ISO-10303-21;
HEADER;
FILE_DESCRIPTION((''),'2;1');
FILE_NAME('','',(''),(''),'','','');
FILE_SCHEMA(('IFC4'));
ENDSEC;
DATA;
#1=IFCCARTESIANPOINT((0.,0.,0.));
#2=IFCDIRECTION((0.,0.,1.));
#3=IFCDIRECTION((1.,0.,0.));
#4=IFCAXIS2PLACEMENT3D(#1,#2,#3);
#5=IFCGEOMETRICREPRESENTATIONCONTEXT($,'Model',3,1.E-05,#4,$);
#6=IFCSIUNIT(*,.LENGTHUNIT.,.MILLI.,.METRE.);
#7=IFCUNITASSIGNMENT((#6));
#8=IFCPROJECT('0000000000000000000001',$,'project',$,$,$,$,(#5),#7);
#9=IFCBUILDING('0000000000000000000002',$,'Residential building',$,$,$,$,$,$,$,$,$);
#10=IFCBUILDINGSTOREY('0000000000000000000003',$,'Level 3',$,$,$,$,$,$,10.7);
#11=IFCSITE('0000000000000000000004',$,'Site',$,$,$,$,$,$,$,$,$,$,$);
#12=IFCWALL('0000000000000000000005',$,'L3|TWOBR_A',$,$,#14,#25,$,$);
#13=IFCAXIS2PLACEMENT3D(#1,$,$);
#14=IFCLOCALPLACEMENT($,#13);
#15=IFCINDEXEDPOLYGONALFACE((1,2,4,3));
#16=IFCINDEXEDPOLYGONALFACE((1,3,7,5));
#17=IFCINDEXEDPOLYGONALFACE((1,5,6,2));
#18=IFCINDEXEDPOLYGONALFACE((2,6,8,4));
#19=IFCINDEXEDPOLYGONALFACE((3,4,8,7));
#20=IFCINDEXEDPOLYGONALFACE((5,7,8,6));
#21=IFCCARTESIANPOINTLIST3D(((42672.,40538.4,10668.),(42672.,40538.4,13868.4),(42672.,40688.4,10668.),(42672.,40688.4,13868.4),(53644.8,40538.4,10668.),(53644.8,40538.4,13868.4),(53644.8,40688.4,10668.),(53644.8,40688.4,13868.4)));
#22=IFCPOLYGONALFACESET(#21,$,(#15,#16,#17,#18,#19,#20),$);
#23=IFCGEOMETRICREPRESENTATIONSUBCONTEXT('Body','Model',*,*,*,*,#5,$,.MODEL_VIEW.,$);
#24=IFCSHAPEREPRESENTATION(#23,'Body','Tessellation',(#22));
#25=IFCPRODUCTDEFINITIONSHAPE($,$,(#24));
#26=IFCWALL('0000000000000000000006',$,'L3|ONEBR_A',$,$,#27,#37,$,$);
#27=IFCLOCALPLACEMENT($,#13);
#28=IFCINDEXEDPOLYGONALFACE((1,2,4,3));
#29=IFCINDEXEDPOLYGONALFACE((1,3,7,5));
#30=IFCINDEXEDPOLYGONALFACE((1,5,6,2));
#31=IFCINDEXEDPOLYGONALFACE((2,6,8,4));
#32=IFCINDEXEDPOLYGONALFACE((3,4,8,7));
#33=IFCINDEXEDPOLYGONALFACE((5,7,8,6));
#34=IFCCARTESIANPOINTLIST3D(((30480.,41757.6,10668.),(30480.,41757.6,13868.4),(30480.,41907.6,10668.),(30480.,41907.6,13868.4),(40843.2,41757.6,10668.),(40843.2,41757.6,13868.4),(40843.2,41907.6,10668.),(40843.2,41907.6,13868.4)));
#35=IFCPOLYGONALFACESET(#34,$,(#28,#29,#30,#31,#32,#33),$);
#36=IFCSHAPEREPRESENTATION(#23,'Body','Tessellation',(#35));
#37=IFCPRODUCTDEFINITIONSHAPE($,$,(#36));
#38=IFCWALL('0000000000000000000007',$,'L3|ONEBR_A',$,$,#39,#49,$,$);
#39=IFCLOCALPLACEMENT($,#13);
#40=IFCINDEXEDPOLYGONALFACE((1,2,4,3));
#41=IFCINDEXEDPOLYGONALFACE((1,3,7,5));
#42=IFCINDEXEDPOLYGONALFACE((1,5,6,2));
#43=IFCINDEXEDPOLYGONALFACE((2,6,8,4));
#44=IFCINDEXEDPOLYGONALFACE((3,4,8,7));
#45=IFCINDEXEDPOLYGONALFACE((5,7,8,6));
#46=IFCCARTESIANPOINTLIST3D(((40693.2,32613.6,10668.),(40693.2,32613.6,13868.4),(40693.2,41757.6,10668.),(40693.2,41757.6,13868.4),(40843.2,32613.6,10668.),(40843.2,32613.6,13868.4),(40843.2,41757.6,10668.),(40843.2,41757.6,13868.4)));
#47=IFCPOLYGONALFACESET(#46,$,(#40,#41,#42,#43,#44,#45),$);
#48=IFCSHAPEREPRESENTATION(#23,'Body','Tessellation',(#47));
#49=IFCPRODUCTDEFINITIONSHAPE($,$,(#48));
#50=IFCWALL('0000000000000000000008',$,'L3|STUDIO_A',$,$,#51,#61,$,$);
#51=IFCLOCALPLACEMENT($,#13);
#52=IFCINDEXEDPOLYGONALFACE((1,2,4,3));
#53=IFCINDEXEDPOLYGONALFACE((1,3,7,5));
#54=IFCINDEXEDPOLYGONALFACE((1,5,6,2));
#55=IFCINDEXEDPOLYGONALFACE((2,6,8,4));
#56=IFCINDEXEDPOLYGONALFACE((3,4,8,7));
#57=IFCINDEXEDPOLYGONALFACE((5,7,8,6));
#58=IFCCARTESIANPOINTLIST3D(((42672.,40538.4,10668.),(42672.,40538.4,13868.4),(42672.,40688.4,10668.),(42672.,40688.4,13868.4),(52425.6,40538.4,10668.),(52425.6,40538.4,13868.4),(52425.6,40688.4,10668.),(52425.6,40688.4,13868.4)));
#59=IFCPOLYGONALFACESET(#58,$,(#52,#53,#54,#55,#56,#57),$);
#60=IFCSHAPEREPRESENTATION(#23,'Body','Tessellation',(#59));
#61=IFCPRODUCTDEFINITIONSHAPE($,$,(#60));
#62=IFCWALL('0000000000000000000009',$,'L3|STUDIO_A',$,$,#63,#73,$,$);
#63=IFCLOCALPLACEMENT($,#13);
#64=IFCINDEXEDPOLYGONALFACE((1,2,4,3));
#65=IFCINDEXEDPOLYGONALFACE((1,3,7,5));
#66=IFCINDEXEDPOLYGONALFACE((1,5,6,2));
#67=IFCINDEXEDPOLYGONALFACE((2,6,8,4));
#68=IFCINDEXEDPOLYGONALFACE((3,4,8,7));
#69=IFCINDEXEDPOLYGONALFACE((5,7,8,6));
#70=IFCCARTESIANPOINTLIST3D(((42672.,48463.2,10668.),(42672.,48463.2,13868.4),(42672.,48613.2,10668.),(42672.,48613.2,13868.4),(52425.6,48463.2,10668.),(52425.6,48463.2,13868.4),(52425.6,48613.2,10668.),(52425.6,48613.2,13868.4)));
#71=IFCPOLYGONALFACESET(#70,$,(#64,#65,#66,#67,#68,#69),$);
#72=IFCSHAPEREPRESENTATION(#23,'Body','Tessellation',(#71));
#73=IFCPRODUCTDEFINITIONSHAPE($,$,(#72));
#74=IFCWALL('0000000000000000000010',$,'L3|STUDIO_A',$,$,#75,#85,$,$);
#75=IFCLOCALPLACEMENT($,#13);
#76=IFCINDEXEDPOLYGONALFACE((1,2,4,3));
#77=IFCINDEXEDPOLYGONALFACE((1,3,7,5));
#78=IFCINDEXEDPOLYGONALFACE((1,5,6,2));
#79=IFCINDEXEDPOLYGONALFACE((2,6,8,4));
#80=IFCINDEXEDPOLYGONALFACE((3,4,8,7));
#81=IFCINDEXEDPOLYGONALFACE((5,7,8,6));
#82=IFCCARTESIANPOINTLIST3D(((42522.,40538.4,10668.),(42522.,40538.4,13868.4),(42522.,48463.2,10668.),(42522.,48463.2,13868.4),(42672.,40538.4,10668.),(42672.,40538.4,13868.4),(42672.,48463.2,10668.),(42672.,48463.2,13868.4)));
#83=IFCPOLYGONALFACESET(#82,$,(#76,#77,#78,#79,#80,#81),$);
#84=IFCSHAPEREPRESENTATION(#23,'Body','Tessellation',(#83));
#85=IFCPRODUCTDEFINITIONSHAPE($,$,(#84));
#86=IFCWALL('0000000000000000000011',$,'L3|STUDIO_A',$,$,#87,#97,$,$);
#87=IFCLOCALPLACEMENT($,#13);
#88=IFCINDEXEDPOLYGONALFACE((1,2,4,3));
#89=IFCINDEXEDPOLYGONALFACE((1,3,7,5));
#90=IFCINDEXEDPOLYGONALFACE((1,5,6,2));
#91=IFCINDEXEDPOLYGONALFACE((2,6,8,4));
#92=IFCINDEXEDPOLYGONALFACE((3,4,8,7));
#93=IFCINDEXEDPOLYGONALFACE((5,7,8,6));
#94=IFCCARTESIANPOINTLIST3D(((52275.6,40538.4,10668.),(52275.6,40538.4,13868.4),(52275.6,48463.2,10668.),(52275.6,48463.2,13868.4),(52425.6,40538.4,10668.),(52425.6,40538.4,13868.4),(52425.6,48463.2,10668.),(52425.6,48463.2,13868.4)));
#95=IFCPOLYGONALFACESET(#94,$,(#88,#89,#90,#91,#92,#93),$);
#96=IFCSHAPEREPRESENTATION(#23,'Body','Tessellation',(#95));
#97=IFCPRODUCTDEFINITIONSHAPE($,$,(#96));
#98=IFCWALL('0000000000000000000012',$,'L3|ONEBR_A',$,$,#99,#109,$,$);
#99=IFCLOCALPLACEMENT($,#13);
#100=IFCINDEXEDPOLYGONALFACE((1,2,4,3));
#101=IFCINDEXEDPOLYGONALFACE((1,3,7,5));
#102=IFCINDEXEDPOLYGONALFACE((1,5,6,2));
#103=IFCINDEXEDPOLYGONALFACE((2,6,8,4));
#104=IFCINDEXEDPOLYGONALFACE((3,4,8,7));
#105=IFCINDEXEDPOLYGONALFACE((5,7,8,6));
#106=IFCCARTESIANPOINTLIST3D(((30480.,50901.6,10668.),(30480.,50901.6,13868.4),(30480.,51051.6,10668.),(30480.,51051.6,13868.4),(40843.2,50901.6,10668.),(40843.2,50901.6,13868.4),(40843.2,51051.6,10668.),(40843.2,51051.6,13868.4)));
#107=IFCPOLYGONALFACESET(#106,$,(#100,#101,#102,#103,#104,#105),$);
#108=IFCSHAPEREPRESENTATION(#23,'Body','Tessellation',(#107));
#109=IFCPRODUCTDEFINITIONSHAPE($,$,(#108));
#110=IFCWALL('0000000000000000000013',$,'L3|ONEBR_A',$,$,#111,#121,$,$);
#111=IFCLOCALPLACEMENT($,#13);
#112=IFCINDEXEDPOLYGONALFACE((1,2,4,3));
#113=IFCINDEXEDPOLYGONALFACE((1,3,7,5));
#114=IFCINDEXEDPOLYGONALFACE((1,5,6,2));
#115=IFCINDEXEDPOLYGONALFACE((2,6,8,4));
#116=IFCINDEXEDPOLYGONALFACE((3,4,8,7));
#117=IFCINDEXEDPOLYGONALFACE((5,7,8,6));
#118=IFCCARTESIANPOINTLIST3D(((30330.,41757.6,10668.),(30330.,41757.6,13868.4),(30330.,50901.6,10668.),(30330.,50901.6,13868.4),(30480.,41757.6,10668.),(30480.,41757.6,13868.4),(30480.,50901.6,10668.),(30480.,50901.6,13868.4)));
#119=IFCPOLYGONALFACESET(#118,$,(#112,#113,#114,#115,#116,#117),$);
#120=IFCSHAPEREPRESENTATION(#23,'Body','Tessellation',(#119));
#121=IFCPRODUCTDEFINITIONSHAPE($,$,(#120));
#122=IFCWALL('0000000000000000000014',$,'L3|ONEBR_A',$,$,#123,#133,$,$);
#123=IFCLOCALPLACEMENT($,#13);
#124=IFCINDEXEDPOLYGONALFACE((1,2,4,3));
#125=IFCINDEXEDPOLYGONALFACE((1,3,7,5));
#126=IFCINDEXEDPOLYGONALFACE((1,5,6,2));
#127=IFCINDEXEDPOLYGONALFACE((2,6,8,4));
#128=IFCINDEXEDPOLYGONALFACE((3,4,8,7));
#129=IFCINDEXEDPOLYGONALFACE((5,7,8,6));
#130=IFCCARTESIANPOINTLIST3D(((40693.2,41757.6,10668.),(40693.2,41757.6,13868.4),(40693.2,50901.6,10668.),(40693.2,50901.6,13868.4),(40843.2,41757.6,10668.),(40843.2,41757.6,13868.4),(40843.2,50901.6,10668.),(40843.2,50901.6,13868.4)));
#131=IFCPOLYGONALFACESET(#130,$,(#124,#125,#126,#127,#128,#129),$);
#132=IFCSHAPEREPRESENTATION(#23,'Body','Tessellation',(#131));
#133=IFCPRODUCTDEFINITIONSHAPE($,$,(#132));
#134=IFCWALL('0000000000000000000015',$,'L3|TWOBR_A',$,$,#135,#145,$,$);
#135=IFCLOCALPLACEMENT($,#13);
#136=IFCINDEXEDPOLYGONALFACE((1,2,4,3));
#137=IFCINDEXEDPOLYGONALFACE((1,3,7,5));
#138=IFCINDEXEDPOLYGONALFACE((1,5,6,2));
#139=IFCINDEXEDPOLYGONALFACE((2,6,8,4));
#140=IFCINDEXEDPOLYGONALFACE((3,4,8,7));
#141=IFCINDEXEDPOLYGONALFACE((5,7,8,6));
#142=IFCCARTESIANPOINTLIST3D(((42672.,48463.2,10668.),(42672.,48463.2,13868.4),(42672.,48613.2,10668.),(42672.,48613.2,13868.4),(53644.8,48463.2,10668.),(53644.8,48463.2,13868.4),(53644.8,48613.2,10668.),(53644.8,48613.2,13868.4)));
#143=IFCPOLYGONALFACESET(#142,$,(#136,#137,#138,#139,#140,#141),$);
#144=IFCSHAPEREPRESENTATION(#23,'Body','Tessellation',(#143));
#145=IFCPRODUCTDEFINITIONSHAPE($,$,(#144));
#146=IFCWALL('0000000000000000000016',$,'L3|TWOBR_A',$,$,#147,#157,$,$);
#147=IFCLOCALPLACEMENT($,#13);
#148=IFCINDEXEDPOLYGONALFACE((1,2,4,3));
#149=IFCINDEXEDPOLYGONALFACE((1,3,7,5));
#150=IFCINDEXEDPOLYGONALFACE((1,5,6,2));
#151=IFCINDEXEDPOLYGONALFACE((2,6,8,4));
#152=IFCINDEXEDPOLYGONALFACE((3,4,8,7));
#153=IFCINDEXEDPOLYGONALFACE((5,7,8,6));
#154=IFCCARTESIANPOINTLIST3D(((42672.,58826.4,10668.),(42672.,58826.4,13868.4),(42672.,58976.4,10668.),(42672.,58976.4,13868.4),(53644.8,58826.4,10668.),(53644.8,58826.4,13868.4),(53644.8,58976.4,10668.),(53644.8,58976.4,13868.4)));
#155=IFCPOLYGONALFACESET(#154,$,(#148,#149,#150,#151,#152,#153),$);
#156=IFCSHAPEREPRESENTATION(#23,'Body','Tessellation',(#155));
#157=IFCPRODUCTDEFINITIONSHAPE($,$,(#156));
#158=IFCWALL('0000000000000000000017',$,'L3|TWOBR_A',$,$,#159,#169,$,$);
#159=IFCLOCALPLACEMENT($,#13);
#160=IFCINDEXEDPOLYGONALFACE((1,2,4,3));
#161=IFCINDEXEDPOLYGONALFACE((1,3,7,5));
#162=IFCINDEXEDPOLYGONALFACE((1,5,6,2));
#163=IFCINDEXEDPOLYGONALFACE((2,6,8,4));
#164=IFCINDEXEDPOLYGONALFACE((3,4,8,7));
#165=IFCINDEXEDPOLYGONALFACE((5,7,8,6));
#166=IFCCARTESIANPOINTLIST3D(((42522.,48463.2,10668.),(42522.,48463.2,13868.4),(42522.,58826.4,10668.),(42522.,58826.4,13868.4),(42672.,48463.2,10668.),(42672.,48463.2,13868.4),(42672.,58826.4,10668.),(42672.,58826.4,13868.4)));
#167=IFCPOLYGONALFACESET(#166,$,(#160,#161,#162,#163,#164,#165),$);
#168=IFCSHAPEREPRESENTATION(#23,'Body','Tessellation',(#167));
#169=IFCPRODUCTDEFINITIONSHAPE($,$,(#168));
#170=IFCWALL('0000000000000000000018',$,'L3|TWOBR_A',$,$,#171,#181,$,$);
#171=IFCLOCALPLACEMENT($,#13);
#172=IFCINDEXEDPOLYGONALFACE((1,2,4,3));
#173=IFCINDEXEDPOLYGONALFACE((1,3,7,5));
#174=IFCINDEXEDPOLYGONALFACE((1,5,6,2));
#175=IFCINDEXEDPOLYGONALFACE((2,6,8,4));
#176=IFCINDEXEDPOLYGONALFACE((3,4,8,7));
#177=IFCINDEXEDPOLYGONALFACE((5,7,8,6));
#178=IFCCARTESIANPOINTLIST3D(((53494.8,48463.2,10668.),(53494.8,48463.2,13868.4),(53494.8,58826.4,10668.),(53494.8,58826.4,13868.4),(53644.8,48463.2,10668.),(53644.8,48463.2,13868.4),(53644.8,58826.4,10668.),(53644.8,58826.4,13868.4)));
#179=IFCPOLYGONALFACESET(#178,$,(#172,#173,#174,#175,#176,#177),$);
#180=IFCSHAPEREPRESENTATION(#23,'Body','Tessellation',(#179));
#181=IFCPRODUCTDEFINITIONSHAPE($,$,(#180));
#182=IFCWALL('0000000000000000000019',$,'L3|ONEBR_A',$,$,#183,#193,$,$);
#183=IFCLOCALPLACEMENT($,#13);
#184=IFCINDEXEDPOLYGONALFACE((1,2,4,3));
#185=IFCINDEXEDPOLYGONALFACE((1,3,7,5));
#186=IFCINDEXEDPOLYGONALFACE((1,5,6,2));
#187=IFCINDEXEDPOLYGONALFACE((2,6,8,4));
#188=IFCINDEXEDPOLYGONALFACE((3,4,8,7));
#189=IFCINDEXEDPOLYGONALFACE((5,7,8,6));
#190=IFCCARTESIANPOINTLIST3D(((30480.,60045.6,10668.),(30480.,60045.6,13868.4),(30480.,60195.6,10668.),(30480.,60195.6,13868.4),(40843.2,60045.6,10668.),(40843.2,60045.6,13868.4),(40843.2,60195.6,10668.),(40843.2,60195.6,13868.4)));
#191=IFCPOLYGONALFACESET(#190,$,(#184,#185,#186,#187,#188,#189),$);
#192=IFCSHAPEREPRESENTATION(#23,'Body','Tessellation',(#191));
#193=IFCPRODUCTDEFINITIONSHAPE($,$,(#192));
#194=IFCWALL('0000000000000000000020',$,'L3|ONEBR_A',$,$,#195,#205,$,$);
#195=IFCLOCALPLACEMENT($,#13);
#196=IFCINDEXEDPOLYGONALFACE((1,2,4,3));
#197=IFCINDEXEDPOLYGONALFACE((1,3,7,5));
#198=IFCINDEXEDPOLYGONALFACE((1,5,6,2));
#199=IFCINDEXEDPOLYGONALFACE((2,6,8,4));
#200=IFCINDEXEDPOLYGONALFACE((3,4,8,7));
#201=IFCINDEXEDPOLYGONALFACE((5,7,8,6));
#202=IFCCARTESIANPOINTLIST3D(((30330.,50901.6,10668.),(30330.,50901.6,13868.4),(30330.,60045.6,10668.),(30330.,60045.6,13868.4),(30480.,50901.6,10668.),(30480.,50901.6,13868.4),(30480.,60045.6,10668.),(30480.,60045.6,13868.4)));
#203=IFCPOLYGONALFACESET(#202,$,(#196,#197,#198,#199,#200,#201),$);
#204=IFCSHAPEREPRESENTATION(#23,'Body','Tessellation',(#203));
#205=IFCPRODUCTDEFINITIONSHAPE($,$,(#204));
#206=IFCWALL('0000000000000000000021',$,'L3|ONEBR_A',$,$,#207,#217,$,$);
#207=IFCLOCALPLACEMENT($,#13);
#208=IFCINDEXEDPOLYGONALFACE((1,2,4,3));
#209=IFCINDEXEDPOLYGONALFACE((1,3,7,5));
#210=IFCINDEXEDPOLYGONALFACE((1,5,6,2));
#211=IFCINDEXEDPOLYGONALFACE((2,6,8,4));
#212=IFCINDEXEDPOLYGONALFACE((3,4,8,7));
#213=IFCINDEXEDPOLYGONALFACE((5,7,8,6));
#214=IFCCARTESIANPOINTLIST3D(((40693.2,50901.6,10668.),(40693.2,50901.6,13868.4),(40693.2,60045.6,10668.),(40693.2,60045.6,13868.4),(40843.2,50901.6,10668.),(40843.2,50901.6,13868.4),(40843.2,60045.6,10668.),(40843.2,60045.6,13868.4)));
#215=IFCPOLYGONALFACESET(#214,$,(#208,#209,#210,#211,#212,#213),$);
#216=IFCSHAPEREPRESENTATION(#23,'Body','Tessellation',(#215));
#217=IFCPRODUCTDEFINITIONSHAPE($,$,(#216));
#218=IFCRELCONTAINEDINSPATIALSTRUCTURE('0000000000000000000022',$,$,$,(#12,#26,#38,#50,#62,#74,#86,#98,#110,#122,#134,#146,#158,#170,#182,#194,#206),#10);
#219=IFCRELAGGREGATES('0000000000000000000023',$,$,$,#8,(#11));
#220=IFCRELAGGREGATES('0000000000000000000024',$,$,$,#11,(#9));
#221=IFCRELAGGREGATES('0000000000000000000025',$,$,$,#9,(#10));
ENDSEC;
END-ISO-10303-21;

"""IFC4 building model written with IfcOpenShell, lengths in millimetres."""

from ifc_helpers import new_model, si_unit, frame, origin_with_axes, place, context, subcontext, project, spatial, indexed_curve, outline, extrude, element, save


model = new_model("IFC4")

# Units and contexts
model_context = context("Model", 3, precision=1e-05, world=origin_with_axes())
body_context = subcontext(model_context, "Body", "Model", "MODEL_VIEW")
ifc_project = project(units=[si_unit("LENGTHUNIT", "METRE", prefix="MILLI")], contexts=[model_context])

# Site, building, storey
site = spatial("IfcSite", under=ifc_project, Name="Site")
building = spatial("IfcBuilding", under=site, Name="Residential building")
storey = spatial("IfcBuildingStorey", under=building, Name="Level 3", Elevation=10.7)

# Walls
wall_1_placement = place(None, frame((42672.0, 40538.4, 10668.0), z_axis=(0.0, 0.0, 1.0), x_axis=(1.0, 0.0, 0.0)))
element("IfcWall", 1, at=wall_1_placement, inside=storey, Name="L3|TWOBR_A", context=body_context, shape_type="SweptSolid", body=[
    extrude(outline(indexed_curve([(0.0, 0.0), (0.0, 150.0), (10972.8, 150.0), (10972.8, 0.0), (0.0, 0.0)], self_intersect=False)), origin_with_axes(), (0.0, 0.0, 1.0), 3200.4),
])
wall_2_placement = place(None, frame((30480.0, 41757.6, 10668.0), z_axis=(0.0, 0.0, 1.0), x_axis=(1.0, 0.0, 0.0)))
element("IfcWall", 2, at=wall_2_placement, inside=storey, Name="L3|ONEBR_A", context=body_context, shape_type="SweptSolid", body=[
    extrude(outline(indexed_curve([(0.0, 0.0), (0.0, 150.0), (10363.2, 150.0), (10363.2, 0.0), (0.0, 0.0)], self_intersect=False)), origin_with_axes(), (0.0, 0.0, 1.0), 3200.4),
])
wall_3_placement = place(None, frame((40843.2, 32613.6, 10668.0), z_axis=(0.0, 0.0, 1.0), x_axis=(0.0, 1.0, 0.0)))
element("IfcWall", 3, at=wall_3_placement, inside=storey, Name="L3|ONEBR_A", context=body_context, shape_type="SweptSolid", body=[
    extrude(outline(indexed_curve([(0.0, 0.0), (0.0, 150.0), (9144.0, 150.0), (9144.0, 0.0), (0.0, 0.0)], self_intersect=False)), origin_with_axes(), (0.0, 0.0, 1.0), 3200.4),
])
for number, where, z_axis, x_axis, name in (
    (4, (42672.0, 40538.4, 10668.0), (0.0, 0.0, 1.0), (1.0, 0.0, 0.0), "L3|STUDIO_A"),
    (5, (42672.0, 48463.2, 10668.0), (0.0, 0.0, 1.0), (1.0, 0.0, 0.0), "L3|STUDIO_A"),
):
    element("IfcWall", number, at=place(None, frame(where, z_axis=z_axis, x_axis=x_axis)), inside=storey, Name=name, context=body_context, shape_type="SweptSolid", body=[
        extrude(outline(indexed_curve([(0.0, 0.0), (0.0, 150.0), (9753.6, 150.0), (9753.6, 0.0), (0.0, 0.0)], self_intersect=False)), origin_with_axes(), (0.0, 0.0, 1.0), 3200.4),
    ])
for number, where, z_axis, x_axis, name in (
    (6, (42672.0, 40538.4, 10668.0), (0.0, 0.0, 1.0), (0.0, 1.0, 0.0), "L3|STUDIO_A"),
    (7, (52425.6, 40538.4, 10668.0), (0.0, 0.0, 1.0), (0.0, 1.0, 0.0), "L3|STUDIO_A"),
):
    element("IfcWall", number, at=place(None, frame(where, z_axis=z_axis, x_axis=x_axis)), inside=storey, Name=name, context=body_context, shape_type="SweptSolid", body=[
        extrude(outline(indexed_curve([(0.0, 0.0), (0.0, 150.0), (7924.8, 150.0), (7924.8, 0.0), (0.0, 0.0)], self_intersect=False)), origin_with_axes(), (0.0, 0.0, 1.0), 3200.4),
    ])
for number, where, z_axis, x_axis, name in (
    (8, (30480.0, 50901.6, 10668.0), (0.0, 0.0, 1.0), (1.0, 0.0, 0.0), "L3|ONEBR_A"),
):
    element("IfcWall", number, at=place(None, frame(where, z_axis=z_axis, x_axis=x_axis)), inside=storey, Name=name, context=body_context, shape_type="SweptSolid", body=[
        extrude(outline(indexed_curve([(0.0, 0.0), (0.0, 150.0), (10363.2, 150.0), (10363.2, 0.0), (0.0, 0.0)], self_intersect=False)), origin_with_axes(), (0.0, 0.0, 1.0), 3200.4),
    ])
for number, where, z_axis, x_axis, name in (
    (9, (30480.0, 41757.6, 10668.0), (0.0, 0.0, 1.0), (0.0, 1.0, 0.0), "L3|ONEBR_A"),
    (10, (40843.2, 41757.6, 10668.0), (0.0, 0.0, 1.0), (0.0, 1.0, 0.0), "L3|ONEBR_A"),
):
    element("IfcWall", number, at=place(None, frame(where, z_axis=z_axis, x_axis=x_axis)), inside=storey, Name=name, context=body_context, shape_type="SweptSolid", body=[
        extrude(outline(indexed_curve([(0.0, 0.0), (0.0, 150.0), (9144.0, 150.0), (9144.0, 0.0), (0.0, 0.0)], self_intersect=False)), origin_with_axes(), (0.0, 0.0, 1.0), 3200.4),
    ])
for number, where, z_axis, x_axis, name in (
    (11, (42672.0, 48463.2, 10668.0), (0.0, 0.0, 1.0), (1.0, 0.0, 0.0), "L3|TWOBR_A"),
    (12, (42672.0, 58826.4, 10668.0), (0.0, 0.0, 1.0), (1.0, 0.0, 0.0), "L3|TWOBR_A"),
):
    element("IfcWall", number, at=place(None, frame(where, z_axis=z_axis, x_axis=x_axis)), inside=storey, Name=name, context=body_context, shape_type="SweptSolid", body=[
        extrude(outline(indexed_curve([(0.0, 0.0), (0.0, 150.0), (10972.8, 150.0), (10972.8, 0.0), (0.0, 0.0)], self_intersect=False)), origin_with_axes(), (0.0, 0.0, 1.0), 3200.4),
    ])
for number, where, z_axis, x_axis, name in (
    (13, (42672.0, 48463.2, 10668.0), (0.0, 0.0, 1.0), (0.0, 1.0, 0.0), "L3|TWOBR_A"),
    (14, (53644.8, 48463.2, 10668.0), (0.0, 0.0, 1.0), (0.0, 1.0, 0.0), "L3|TWOBR_A"),
    (15, (30480.0, 60045.6, 10668.0), (0.0, 0.0, 1.0), (1.0, 0.0, 0.0), "L3|ONEBR_A"),
):
    element("IfcWall", number, at=place(None, frame(where, z_axis=z_axis, x_axis=x_axis)), inside=storey, Name=name, context=body_context, shape_type="SweptSolid", body=[
        extrude(outline(indexed_curve([(0.0, 0.0), (0.0, 150.0), (10363.2, 150.0), (10363.2, 0.0), (0.0, 0.0)], self_intersect=False)), origin_with_axes(), (0.0, 0.0, 1.0), 3200.4),
    ])
for number, where, z_axis, x_axis, name in (
    (16, (30480.0, 50901.6, 10668.0), (0.0, 0.0, 1.0), (0.0, 1.0, 0.0), "L3|ONEBR_A"),
    (17, (40843.2, 50901.6, 10668.0), (0.0, 0.0, 1.0), (0.0, 1.0, 0.0), "L3|ONEBR_A"),
):
    element("IfcWall", number, at=place(None, frame(where, z_axis=z_axis, x_axis=x_axis)), inside=storey, Name=name, context=body_context, shape_type="SweptSolid", body=[
        extrude(outline(indexed_curve([(0.0, 0.0), (0.0, 150.0), (9144.0, 150.0), (9144.0, 0.0), (0.0, 0.0)], self_intersect=False)), origin_with_axes(), (0.0, 0.0, 1.0), 3200.4),
    ])

save(model, "model.ifc")
